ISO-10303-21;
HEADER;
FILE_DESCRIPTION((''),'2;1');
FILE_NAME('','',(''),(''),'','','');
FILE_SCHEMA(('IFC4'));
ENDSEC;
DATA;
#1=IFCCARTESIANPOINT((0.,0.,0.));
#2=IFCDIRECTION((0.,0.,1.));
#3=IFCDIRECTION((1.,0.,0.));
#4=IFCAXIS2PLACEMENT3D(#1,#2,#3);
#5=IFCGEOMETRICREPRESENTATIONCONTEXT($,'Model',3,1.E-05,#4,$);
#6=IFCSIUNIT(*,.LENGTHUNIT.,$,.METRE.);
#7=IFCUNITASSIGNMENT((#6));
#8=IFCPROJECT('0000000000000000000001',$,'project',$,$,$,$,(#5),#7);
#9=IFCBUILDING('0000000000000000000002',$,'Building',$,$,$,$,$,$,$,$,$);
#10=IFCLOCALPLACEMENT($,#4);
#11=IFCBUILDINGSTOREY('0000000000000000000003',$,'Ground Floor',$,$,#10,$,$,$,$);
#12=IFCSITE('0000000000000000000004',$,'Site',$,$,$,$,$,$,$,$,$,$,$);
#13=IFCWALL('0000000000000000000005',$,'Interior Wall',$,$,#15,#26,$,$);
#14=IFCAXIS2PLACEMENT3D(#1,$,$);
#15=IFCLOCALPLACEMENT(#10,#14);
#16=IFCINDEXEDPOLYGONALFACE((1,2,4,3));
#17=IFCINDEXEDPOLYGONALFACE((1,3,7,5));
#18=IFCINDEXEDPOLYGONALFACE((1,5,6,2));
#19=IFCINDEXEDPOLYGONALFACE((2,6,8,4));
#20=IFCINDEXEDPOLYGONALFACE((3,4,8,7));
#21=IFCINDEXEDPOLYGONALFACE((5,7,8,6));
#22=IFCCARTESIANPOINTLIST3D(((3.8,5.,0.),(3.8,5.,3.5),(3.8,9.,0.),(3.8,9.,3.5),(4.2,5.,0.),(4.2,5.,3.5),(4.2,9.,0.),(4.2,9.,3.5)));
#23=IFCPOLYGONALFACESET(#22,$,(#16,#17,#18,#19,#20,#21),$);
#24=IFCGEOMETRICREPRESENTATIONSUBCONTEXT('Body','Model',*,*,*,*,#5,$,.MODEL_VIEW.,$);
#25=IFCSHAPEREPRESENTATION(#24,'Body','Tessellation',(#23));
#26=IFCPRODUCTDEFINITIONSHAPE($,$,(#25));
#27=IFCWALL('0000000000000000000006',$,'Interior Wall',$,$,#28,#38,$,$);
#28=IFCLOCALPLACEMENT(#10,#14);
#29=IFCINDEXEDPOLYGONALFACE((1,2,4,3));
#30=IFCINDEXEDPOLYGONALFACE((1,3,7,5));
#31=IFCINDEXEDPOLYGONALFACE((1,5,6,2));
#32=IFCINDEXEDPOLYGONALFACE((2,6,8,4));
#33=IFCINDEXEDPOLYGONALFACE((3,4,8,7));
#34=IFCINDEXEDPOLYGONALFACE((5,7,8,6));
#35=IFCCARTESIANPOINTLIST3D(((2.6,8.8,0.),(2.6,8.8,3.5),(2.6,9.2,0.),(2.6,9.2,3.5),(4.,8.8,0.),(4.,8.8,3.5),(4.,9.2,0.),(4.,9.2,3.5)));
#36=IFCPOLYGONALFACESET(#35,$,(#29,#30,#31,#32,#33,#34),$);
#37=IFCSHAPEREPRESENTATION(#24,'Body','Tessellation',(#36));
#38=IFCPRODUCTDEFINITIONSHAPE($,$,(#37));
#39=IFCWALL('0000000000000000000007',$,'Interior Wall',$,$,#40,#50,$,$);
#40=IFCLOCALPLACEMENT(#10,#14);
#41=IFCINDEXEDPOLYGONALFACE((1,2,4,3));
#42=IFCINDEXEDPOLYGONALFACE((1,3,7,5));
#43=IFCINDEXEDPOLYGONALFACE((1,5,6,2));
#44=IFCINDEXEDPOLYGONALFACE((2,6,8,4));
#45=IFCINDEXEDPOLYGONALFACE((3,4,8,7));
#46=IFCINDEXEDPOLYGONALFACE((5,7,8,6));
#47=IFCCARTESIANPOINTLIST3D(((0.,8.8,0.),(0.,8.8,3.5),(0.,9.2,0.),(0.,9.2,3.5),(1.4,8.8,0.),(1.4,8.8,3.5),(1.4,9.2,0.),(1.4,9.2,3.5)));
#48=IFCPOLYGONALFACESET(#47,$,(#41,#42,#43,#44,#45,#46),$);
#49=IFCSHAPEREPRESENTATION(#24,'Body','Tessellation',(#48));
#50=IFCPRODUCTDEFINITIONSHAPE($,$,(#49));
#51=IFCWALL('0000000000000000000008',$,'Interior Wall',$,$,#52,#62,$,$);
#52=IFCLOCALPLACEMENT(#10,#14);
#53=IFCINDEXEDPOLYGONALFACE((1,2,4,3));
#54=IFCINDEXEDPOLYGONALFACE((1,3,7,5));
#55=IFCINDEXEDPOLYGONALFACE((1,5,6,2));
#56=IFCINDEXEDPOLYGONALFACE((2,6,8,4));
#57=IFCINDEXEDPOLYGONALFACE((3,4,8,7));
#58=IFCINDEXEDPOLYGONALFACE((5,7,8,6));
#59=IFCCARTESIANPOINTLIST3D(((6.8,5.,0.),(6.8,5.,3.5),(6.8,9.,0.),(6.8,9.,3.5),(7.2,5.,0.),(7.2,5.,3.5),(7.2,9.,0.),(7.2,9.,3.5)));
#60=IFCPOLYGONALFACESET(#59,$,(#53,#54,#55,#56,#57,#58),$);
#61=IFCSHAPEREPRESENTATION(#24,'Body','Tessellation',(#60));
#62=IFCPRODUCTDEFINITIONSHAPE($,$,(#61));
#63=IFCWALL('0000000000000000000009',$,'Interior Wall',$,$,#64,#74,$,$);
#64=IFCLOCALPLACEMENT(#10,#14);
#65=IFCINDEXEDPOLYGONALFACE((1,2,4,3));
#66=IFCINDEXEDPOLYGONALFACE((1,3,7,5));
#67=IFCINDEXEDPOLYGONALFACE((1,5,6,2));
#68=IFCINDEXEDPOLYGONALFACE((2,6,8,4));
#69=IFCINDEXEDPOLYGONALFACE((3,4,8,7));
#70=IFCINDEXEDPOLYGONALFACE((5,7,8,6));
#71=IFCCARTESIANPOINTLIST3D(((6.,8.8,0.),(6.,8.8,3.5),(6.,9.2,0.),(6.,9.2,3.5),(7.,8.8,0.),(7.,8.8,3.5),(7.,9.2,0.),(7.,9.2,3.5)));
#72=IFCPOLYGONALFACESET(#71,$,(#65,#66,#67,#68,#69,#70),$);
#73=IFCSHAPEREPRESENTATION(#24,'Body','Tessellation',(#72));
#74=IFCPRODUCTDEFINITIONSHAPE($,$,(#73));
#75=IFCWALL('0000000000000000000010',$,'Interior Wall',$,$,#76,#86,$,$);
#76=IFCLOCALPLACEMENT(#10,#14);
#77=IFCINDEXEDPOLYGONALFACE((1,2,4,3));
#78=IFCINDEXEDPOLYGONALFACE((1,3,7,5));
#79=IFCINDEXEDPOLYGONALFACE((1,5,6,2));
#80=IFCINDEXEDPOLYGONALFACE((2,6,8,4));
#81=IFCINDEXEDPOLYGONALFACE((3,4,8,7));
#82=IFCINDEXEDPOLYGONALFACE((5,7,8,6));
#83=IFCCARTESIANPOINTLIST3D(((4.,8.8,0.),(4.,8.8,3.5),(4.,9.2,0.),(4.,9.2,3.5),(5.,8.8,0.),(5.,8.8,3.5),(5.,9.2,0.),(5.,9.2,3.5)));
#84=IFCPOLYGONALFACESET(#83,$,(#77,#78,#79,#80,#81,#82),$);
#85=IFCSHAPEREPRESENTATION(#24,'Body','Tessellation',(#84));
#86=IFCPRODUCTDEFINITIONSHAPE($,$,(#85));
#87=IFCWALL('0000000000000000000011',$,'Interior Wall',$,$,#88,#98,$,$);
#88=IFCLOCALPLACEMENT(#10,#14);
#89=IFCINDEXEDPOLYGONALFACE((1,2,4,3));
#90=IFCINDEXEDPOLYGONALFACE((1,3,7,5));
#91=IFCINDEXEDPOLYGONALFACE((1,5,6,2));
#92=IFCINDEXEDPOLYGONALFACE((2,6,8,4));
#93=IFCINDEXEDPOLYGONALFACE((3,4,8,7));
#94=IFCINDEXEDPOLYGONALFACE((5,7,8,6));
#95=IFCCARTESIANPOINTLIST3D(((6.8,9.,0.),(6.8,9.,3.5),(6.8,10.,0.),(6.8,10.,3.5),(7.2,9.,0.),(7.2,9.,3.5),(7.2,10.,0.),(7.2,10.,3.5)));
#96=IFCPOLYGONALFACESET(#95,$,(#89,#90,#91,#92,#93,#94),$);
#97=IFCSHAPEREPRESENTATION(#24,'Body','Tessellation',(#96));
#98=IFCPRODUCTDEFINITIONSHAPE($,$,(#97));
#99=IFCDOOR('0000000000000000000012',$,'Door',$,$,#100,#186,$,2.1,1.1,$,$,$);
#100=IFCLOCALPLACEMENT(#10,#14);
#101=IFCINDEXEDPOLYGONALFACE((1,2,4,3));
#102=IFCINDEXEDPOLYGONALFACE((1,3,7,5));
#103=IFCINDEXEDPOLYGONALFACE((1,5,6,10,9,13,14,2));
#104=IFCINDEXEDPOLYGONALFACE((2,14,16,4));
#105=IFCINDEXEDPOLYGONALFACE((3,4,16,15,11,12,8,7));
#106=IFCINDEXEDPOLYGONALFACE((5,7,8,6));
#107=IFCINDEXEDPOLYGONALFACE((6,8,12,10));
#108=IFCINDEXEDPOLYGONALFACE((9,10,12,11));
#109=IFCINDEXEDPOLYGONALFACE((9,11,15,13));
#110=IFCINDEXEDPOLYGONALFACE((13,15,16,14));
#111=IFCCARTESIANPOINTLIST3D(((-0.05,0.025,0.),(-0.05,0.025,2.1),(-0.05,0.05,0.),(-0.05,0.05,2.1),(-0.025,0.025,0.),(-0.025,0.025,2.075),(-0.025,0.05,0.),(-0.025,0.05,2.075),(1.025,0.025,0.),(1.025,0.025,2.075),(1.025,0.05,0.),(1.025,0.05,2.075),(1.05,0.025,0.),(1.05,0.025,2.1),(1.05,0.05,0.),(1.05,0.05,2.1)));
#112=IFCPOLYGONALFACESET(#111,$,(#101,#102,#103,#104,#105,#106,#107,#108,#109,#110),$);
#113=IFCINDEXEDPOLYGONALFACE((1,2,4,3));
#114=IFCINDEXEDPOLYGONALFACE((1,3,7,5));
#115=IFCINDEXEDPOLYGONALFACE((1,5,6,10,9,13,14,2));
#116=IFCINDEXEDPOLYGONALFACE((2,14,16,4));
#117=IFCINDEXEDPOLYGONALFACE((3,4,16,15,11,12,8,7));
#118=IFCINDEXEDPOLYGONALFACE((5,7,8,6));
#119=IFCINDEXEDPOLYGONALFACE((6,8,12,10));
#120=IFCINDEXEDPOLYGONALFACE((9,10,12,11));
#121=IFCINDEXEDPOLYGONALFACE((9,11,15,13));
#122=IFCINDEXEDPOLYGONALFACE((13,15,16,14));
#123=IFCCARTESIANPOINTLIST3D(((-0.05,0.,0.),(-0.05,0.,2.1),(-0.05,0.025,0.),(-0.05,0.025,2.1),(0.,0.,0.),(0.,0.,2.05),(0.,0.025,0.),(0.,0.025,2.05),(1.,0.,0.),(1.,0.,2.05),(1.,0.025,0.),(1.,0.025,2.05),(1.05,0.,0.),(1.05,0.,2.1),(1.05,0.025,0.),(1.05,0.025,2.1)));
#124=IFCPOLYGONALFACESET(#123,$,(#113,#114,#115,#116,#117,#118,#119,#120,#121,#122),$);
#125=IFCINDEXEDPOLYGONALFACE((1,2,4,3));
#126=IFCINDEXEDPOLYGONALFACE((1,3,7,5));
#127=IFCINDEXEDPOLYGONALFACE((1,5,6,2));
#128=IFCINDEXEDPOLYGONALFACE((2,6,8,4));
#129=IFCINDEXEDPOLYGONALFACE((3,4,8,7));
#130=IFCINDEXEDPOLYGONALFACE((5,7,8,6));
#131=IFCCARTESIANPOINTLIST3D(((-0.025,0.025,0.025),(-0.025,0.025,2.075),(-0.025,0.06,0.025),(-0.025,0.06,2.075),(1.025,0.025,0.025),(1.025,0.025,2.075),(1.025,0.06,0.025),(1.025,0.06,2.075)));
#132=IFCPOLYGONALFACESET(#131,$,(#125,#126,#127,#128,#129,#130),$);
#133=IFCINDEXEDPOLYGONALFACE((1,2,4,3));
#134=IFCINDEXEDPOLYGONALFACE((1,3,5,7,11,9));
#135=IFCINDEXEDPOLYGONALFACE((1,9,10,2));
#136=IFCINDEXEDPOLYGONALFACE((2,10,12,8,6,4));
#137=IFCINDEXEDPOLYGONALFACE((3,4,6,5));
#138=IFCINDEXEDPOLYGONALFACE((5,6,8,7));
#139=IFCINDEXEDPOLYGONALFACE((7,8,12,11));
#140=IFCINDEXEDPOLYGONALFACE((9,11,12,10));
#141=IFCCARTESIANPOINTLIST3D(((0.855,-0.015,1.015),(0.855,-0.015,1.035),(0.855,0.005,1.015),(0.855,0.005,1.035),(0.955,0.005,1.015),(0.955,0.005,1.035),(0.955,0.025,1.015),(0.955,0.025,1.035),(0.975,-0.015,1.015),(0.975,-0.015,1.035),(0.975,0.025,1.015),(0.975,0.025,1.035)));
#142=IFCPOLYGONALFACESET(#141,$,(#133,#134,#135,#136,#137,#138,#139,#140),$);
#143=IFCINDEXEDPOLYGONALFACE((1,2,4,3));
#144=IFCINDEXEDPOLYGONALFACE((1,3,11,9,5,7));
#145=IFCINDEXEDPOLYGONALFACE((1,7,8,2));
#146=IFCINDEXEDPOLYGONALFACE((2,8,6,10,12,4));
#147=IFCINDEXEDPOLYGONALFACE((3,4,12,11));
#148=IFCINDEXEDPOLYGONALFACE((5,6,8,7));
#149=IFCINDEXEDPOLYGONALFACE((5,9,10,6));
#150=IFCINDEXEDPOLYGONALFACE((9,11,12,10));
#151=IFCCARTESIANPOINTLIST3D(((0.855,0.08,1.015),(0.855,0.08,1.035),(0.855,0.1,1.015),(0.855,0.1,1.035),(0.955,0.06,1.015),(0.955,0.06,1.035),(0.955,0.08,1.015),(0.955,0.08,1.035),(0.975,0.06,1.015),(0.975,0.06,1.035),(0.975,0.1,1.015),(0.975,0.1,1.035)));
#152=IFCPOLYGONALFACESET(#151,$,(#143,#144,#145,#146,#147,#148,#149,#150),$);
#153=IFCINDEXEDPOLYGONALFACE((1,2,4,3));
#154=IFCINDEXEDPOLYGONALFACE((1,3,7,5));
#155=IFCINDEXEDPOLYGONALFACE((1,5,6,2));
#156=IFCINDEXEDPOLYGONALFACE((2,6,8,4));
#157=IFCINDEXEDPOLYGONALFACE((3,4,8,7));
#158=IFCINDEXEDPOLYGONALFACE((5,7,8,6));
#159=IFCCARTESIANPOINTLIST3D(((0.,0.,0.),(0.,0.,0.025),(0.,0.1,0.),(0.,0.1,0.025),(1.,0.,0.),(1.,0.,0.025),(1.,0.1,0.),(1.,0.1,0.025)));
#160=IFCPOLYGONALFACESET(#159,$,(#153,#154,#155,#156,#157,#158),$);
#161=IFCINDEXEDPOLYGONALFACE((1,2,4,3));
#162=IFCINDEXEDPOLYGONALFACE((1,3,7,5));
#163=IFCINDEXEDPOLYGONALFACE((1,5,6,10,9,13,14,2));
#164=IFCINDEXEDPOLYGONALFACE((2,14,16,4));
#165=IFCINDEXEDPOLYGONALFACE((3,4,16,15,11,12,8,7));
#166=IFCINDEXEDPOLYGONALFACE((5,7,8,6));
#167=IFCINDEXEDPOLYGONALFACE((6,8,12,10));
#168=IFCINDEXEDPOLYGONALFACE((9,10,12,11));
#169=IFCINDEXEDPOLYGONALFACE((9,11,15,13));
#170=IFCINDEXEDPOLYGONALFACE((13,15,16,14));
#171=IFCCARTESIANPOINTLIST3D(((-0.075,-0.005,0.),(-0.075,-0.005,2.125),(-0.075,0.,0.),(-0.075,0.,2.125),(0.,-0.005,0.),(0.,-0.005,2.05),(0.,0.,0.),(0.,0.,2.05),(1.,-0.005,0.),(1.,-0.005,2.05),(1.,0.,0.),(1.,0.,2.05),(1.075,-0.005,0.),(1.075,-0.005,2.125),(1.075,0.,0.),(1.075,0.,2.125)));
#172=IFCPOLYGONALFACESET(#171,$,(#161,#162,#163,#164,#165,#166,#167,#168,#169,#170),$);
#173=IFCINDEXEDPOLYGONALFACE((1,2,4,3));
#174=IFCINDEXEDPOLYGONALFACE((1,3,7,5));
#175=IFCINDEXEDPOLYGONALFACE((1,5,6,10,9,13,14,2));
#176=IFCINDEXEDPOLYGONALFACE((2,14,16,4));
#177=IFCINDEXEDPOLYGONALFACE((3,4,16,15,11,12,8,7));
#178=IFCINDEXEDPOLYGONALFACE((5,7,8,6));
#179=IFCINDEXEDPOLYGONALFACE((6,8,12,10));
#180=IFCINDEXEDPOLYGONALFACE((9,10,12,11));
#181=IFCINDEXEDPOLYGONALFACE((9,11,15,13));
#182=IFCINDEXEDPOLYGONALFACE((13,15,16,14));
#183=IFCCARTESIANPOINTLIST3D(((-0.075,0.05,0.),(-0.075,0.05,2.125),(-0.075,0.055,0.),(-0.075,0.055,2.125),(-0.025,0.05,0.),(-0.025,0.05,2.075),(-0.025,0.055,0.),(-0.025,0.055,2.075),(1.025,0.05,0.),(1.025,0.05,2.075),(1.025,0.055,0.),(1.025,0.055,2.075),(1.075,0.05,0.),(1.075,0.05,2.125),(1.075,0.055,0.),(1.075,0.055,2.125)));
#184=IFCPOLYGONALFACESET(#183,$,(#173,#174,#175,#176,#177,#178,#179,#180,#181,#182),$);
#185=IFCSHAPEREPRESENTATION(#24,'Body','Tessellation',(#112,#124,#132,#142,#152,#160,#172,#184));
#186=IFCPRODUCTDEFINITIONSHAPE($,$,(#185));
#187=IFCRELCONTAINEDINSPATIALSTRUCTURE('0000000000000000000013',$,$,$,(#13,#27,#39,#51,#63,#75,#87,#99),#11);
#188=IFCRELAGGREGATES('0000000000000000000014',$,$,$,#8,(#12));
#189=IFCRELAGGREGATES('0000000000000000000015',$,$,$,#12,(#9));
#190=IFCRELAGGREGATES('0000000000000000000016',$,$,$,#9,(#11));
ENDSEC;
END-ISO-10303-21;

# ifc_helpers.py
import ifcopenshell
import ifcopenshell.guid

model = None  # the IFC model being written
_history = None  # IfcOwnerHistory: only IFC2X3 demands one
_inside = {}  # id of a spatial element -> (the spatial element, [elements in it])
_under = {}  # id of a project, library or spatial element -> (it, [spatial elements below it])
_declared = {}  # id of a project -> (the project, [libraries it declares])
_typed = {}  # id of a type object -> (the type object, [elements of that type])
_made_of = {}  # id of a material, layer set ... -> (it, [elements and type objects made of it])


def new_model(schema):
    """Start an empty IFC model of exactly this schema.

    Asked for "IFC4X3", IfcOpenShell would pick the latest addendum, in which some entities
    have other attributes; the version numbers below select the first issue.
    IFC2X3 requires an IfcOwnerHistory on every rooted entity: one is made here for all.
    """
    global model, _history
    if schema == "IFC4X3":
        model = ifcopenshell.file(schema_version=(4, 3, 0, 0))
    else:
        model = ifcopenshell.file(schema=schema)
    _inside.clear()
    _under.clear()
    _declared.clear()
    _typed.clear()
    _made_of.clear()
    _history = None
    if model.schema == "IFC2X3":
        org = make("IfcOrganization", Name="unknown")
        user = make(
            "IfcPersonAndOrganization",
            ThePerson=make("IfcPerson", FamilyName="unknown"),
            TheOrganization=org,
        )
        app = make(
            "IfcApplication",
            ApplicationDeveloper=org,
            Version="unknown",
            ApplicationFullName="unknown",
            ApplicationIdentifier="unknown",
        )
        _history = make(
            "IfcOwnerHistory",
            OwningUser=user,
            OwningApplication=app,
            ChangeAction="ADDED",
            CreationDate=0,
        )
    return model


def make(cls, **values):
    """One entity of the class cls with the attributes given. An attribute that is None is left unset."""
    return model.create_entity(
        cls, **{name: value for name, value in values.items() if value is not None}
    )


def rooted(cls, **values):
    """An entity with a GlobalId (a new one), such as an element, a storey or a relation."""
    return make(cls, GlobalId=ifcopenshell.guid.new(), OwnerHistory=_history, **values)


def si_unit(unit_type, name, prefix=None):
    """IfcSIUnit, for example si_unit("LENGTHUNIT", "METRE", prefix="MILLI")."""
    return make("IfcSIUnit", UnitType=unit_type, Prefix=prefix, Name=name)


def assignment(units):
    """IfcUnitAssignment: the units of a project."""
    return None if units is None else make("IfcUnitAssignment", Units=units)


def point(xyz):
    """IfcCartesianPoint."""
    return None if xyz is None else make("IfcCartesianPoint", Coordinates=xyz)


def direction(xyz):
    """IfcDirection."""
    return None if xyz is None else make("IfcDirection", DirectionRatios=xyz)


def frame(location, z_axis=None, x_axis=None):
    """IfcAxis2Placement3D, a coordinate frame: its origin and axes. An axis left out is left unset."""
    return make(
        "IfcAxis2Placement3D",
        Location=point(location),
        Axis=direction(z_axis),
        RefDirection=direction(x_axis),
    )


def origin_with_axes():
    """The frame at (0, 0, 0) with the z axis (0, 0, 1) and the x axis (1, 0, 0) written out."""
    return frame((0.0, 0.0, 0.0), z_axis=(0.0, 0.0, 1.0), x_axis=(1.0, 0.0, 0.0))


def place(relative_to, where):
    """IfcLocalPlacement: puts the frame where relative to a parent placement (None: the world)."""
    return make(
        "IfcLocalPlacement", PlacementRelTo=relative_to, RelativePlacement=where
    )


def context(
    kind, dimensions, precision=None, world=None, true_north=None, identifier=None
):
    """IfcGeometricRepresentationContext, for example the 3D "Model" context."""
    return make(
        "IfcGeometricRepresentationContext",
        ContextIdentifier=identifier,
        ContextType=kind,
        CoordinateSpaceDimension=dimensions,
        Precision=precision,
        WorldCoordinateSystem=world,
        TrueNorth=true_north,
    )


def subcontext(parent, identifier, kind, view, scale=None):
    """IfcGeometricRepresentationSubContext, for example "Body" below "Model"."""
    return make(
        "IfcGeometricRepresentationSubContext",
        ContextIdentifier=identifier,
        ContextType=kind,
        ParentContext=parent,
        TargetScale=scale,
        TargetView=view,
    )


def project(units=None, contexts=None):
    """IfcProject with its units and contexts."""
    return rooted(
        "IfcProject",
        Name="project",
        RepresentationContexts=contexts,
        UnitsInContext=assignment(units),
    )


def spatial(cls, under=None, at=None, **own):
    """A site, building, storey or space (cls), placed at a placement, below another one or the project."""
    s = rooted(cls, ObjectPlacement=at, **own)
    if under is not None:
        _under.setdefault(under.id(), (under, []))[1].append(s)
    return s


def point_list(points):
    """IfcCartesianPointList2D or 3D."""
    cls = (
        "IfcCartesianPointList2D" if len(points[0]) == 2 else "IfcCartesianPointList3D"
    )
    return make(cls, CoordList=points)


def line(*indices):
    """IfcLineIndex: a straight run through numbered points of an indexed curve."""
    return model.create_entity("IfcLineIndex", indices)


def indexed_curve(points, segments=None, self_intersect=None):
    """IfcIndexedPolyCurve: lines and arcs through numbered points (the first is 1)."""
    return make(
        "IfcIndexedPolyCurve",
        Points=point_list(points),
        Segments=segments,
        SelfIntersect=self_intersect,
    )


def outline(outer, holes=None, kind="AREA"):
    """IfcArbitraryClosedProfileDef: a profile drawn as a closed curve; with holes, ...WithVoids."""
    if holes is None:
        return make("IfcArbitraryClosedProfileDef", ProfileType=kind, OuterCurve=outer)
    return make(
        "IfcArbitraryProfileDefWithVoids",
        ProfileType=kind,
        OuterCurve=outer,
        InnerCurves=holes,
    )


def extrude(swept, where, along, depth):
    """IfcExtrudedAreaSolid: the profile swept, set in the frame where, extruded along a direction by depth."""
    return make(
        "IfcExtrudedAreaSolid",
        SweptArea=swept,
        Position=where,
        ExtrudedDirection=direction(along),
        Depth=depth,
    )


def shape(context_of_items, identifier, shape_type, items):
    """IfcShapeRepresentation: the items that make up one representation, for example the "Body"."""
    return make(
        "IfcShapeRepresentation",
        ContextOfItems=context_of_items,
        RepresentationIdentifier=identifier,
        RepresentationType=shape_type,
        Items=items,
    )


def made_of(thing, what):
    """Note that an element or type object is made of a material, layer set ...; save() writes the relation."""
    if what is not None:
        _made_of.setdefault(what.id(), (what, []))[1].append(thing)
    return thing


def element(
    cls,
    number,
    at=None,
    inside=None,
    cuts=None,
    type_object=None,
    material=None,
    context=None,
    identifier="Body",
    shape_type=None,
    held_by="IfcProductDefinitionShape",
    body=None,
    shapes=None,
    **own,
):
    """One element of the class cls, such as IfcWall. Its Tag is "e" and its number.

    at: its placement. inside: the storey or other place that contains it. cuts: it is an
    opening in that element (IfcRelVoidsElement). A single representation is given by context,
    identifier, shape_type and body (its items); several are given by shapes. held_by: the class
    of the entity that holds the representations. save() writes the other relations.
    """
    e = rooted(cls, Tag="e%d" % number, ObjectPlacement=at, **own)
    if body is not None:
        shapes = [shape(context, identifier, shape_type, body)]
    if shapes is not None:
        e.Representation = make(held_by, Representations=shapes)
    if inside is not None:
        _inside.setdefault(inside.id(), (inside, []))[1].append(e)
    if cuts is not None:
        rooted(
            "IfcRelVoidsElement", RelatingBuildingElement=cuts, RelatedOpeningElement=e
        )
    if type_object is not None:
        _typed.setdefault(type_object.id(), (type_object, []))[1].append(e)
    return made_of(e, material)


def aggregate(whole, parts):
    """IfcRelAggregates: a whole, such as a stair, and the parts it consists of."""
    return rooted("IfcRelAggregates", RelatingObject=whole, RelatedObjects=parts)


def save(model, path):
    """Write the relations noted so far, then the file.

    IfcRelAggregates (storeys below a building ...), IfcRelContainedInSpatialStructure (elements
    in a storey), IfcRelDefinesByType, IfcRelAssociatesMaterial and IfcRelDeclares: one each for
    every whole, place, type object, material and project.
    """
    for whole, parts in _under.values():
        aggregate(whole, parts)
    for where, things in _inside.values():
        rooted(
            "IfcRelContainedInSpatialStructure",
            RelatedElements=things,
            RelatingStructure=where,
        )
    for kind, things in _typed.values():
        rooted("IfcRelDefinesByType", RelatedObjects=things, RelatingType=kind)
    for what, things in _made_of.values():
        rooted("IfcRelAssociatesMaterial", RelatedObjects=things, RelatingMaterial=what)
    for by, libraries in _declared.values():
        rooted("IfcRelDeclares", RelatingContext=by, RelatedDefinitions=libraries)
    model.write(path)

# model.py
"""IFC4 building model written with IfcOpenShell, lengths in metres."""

from ifc_helpers import new_model, si_unit, frame, origin_with_axes, place, context, subcontext, project, spatial, line, indexed_curve, outline, extrude, element, save


model = new_model("IFC4")

# Units and contexts
model_context = context("Model", 3, precision=1e-05, world=origin_with_axes())
body_context = subcontext(model_context, "Body", "Model", "MODEL_VIEW")
ifc_project = project(units=[si_unit("LENGTHUNIT", "METRE")], contexts=[model_context])

# Site, building, storey
site = spatial("IfcSite", under=ifc_project, Name="Site")
building = spatial("IfcBuilding", under=site, Name="Building")
storey_placement = place(None, origin_with_axes())
storey = spatial("IfcBuildingStorey", under=building, at=storey_placement, Name="Ground Floor")

# Walls
wall_1_placement = place(storey_placement, frame((4.0, 5.0, 0.0), z_axis=(0.0, 0.0, 1.0), x_axis=(0.0, 1.0, 0.0)))
element("IfcWall", 1, at=wall_1_placement, inside=storey, Name="Interior Wall", context=body_context, shape_type="SweptSolid", body=[
    extrude(outline(indexed_curve([(0.0, 0.0), (0.0, 0.4), (4.0, 0.4), (4.0, 0.0), (0.0, 0.0)], self_intersect=False)), frame((0.0, -0.2, 0.0), z_axis=(0.0, 0.0, 1.0), x_axis=(1.0, 0.0, 0.0)), (0.0, 0.0, 1.0), 3.5),
])
for number, where, z_axis, x_axis, name in (
    (2, (4.0, 9.0, 0.0), (0.0, 0.0, 1.0), (-1.0, 0.0, 0.0), "Interior Wall"),
    (3, (1.4, 9.0, 0.0), (0.0, 0.0, 1.0), (-1.0, 0.0, 0.0), "Interior Wall"),
):
    element("IfcWall", number, at=place(storey_placement, frame(where, z_axis=z_axis, x_axis=x_axis)), inside=storey, Name=name, context=body_context, shape_type="SweptSolid", body=[
        extrude(outline(indexed_curve([(0.0, 0.0), (0.0, 0.4), (1.4, 0.4), (1.4, 0.0), (0.0, 0.0)], self_intersect=False)), frame((0.0, -0.2, 0.0), z_axis=(0.0, 0.0, 1.0), x_axis=(1.0, 0.0, 0.0)), (0.0, 0.0, 1.0), 3.5),
    ])
wall_2_placement = place(storey_placement, frame((7.0, 5.0, 0.0), z_axis=(0.0, 0.0, 1.0), x_axis=(0.0, 1.0, 0.0)))
element("IfcWall", 4, at=wall_2_placement, inside=storey, Name="Interior Wall", context=body_context, shape_type="SweptSolid", body=[
    extrude(outline(indexed_curve([(0.0, 0.0), (0.0, 0.4), (4.0, 0.4), (4.0, 0.0), (0.0, 0.0)], self_intersect=False)), frame((0.0, -0.2, 0.0), z_axis=(0.0, 0.0, 1.0), x_axis=(1.0, 0.0, 0.0)), (0.0, 0.0, 1.0), 3.5),
])
for number, where, z_axis, x_axis, name in (
    (5, (7.0, 9.0, 0.0), (0.0, 0.0, 1.0), (-1.0, 0.0, 0.0), "Interior Wall"),
    (6, (5.0, 9.0, 0.0), (0.0, 0.0, 1.0), (-1.0, 0.0, 0.0), "Interior Wall"),
    (7, (7.0, 9.0, 0.0), (0.0, 0.0, 1.0), (0.0, 1.0, 0.0), "Interior Wall"),
):
    element("IfcWall", number, at=place(storey_placement, frame(where, z_axis=z_axis, x_axis=x_axis)), inside=storey, Name=name, context=body_context, shape_type="SweptSolid", body=[
        extrude(outline(indexed_curve([(0.0, 0.0), (0.0, 0.4), (1.0, 0.4), (1.0, 0.0), (0.0, 0.0)], self_intersect=False)), frame((0.0, -0.2, 0.0), z_axis=(0.0, 0.0, 1.0), x_axis=(1.0, 0.0, 0.0)), (0.0, 0.0, 1.0), 3.5),
    ])

# Door
door_1_placement = place(storey_placement, frame((-0.05, 0.0, 0.0), z_axis=(0.0, 0.0, 1.0), x_axis=(1.0, 0.0, 0.0)))
element("IfcDoor", 8, at=door_1_placement, inside=storey, Name="Door", OverallHeight=2.1, OverallWidth=1.1, context=body_context, shape_type="SweptSolid", body=[
    extrude(outline(indexed_curve([(0.0, 0.0), (0.0, 2.1), (1.1, 2.1), (1.1, 0.0), (1.075, 0.0), (1.075, 2.075), (0.025, 2.075), (0.025, 0.0)], segments=[line(1, 2, 3, 4, 5, 6, 7, 8, 1)])), frame((0.0, 0.025, 0.0), z_axis=(0.0, -1.0, 0.0), x_axis=(1.0, 0.0, 0.0)), (0.0, 0.0, -1.0), 0.025),
    extrude(outline(indexed_curve([(0.0, 0.0), (0.0, 2.1), (1.1, 2.1), (1.1, 0.0), (1.05, 0.0), (1.05, 2.05), (0.05, 2.05), (0.05, 0.0)], segments=[line(1, 2, 3, 4, 5, 6, 7, 8, 1)])), frame((0.0, 0.0, 0.0), z_axis=(0.0, -1.0, 0.0), x_axis=(1.0, 0.0, 0.0)), (0.0, 0.0, -1.0), 0.025),
    extrude(outline(indexed_curve([(0.0, 0.0), (1.05, 0.0), (1.05, 0.035), (0.0, 0.035)], segments=[line(1, 2, 3, 4, 1)])), frame((0.025, 0.025, 0.025), z_axis=(0.0, 0.0, 1.0), x_axis=(1.0, 0.0, 0.0)), (0.0, 0.0, 1.0), 2.05),
    extrude(outline(indexed_curve([(0.0, 0.0), (0.0, -0.04), (-0.12, -0.04), (-0.12, -0.02), (-0.02, -0.02), (-0.02, 0.0)], segments=[line(1, 2, 3, 4, 5, 6, 1)])), frame((1.025, 0.025, 1.015), z_axis=(0.0, 0.0, 1.0), x_axis=(1.0, 0.0, 0.0)), (0.0, 0.0, 1.0), 0.02),
    extrude(outline(indexed_curve([(0.0, 0.0), (0.0, 0.04), (-0.12, 0.04), (-0.12, 0.02), (-0.02, 0.02), (-0.02, 0.0)], segments=[line(1, 2, 3, 4, 5, 6, 1)])), frame((1.025, 0.06, 1.015), z_axis=(0.0, 0.0, 1.0), x_axis=(1.0, 0.0, 0.0)), (0.0, 0.0, 1.0), 0.02),
    extrude(outline(indexed_curve([(0.0, 0.0), (1.0, 0.0), (1.0, 0.1), (0.0, 0.1)], segments=[line(1, 2, 3, 4, 1)])), frame((0.05, 0.0, 0.0), z_axis=(0.0, 0.0, 1.0), x_axis=(1.0, 0.0, 0.0)), (0.0, 0.0, 1.0), 0.025),
    extrude(outline(indexed_curve([(0.0, 0.0), (0.0, 2.125), (1.15, 2.125), (1.15, 0.0), (1.075, 0.0), (1.075, 2.05), (0.075, 2.05), (0.075, 0.0)], segments=[line(1, 2, 3, 4, 5, 6, 7, 8, 1)])), frame((-0.025, -0.005, 0.0), z_axis=(0.0, -1.0, 0.0), x_axis=(1.0, 0.0, 0.0)), (0.0, 0.0, -1.0), 0.005),
    extrude(outline(indexed_curve([(0.0, 0.0), (0.0, 2.125), (1.15, 2.125), (1.15, 0.0), (1.1, 0.0), (1.1, 2.075), (0.05, 2.075), (0.05, 0.0)], segments=[line(1, 2, 3, 4, 5, 6, 7, 8, 1)])), frame((-0.025, 0.05, 0.0), z_axis=(0.0, -1.0, 0.0), x_axis=(1.0, 0.0, 0.0)), (0.0, 0.0, -1.0), 0.005),
])

save(model, "model.ifc")
